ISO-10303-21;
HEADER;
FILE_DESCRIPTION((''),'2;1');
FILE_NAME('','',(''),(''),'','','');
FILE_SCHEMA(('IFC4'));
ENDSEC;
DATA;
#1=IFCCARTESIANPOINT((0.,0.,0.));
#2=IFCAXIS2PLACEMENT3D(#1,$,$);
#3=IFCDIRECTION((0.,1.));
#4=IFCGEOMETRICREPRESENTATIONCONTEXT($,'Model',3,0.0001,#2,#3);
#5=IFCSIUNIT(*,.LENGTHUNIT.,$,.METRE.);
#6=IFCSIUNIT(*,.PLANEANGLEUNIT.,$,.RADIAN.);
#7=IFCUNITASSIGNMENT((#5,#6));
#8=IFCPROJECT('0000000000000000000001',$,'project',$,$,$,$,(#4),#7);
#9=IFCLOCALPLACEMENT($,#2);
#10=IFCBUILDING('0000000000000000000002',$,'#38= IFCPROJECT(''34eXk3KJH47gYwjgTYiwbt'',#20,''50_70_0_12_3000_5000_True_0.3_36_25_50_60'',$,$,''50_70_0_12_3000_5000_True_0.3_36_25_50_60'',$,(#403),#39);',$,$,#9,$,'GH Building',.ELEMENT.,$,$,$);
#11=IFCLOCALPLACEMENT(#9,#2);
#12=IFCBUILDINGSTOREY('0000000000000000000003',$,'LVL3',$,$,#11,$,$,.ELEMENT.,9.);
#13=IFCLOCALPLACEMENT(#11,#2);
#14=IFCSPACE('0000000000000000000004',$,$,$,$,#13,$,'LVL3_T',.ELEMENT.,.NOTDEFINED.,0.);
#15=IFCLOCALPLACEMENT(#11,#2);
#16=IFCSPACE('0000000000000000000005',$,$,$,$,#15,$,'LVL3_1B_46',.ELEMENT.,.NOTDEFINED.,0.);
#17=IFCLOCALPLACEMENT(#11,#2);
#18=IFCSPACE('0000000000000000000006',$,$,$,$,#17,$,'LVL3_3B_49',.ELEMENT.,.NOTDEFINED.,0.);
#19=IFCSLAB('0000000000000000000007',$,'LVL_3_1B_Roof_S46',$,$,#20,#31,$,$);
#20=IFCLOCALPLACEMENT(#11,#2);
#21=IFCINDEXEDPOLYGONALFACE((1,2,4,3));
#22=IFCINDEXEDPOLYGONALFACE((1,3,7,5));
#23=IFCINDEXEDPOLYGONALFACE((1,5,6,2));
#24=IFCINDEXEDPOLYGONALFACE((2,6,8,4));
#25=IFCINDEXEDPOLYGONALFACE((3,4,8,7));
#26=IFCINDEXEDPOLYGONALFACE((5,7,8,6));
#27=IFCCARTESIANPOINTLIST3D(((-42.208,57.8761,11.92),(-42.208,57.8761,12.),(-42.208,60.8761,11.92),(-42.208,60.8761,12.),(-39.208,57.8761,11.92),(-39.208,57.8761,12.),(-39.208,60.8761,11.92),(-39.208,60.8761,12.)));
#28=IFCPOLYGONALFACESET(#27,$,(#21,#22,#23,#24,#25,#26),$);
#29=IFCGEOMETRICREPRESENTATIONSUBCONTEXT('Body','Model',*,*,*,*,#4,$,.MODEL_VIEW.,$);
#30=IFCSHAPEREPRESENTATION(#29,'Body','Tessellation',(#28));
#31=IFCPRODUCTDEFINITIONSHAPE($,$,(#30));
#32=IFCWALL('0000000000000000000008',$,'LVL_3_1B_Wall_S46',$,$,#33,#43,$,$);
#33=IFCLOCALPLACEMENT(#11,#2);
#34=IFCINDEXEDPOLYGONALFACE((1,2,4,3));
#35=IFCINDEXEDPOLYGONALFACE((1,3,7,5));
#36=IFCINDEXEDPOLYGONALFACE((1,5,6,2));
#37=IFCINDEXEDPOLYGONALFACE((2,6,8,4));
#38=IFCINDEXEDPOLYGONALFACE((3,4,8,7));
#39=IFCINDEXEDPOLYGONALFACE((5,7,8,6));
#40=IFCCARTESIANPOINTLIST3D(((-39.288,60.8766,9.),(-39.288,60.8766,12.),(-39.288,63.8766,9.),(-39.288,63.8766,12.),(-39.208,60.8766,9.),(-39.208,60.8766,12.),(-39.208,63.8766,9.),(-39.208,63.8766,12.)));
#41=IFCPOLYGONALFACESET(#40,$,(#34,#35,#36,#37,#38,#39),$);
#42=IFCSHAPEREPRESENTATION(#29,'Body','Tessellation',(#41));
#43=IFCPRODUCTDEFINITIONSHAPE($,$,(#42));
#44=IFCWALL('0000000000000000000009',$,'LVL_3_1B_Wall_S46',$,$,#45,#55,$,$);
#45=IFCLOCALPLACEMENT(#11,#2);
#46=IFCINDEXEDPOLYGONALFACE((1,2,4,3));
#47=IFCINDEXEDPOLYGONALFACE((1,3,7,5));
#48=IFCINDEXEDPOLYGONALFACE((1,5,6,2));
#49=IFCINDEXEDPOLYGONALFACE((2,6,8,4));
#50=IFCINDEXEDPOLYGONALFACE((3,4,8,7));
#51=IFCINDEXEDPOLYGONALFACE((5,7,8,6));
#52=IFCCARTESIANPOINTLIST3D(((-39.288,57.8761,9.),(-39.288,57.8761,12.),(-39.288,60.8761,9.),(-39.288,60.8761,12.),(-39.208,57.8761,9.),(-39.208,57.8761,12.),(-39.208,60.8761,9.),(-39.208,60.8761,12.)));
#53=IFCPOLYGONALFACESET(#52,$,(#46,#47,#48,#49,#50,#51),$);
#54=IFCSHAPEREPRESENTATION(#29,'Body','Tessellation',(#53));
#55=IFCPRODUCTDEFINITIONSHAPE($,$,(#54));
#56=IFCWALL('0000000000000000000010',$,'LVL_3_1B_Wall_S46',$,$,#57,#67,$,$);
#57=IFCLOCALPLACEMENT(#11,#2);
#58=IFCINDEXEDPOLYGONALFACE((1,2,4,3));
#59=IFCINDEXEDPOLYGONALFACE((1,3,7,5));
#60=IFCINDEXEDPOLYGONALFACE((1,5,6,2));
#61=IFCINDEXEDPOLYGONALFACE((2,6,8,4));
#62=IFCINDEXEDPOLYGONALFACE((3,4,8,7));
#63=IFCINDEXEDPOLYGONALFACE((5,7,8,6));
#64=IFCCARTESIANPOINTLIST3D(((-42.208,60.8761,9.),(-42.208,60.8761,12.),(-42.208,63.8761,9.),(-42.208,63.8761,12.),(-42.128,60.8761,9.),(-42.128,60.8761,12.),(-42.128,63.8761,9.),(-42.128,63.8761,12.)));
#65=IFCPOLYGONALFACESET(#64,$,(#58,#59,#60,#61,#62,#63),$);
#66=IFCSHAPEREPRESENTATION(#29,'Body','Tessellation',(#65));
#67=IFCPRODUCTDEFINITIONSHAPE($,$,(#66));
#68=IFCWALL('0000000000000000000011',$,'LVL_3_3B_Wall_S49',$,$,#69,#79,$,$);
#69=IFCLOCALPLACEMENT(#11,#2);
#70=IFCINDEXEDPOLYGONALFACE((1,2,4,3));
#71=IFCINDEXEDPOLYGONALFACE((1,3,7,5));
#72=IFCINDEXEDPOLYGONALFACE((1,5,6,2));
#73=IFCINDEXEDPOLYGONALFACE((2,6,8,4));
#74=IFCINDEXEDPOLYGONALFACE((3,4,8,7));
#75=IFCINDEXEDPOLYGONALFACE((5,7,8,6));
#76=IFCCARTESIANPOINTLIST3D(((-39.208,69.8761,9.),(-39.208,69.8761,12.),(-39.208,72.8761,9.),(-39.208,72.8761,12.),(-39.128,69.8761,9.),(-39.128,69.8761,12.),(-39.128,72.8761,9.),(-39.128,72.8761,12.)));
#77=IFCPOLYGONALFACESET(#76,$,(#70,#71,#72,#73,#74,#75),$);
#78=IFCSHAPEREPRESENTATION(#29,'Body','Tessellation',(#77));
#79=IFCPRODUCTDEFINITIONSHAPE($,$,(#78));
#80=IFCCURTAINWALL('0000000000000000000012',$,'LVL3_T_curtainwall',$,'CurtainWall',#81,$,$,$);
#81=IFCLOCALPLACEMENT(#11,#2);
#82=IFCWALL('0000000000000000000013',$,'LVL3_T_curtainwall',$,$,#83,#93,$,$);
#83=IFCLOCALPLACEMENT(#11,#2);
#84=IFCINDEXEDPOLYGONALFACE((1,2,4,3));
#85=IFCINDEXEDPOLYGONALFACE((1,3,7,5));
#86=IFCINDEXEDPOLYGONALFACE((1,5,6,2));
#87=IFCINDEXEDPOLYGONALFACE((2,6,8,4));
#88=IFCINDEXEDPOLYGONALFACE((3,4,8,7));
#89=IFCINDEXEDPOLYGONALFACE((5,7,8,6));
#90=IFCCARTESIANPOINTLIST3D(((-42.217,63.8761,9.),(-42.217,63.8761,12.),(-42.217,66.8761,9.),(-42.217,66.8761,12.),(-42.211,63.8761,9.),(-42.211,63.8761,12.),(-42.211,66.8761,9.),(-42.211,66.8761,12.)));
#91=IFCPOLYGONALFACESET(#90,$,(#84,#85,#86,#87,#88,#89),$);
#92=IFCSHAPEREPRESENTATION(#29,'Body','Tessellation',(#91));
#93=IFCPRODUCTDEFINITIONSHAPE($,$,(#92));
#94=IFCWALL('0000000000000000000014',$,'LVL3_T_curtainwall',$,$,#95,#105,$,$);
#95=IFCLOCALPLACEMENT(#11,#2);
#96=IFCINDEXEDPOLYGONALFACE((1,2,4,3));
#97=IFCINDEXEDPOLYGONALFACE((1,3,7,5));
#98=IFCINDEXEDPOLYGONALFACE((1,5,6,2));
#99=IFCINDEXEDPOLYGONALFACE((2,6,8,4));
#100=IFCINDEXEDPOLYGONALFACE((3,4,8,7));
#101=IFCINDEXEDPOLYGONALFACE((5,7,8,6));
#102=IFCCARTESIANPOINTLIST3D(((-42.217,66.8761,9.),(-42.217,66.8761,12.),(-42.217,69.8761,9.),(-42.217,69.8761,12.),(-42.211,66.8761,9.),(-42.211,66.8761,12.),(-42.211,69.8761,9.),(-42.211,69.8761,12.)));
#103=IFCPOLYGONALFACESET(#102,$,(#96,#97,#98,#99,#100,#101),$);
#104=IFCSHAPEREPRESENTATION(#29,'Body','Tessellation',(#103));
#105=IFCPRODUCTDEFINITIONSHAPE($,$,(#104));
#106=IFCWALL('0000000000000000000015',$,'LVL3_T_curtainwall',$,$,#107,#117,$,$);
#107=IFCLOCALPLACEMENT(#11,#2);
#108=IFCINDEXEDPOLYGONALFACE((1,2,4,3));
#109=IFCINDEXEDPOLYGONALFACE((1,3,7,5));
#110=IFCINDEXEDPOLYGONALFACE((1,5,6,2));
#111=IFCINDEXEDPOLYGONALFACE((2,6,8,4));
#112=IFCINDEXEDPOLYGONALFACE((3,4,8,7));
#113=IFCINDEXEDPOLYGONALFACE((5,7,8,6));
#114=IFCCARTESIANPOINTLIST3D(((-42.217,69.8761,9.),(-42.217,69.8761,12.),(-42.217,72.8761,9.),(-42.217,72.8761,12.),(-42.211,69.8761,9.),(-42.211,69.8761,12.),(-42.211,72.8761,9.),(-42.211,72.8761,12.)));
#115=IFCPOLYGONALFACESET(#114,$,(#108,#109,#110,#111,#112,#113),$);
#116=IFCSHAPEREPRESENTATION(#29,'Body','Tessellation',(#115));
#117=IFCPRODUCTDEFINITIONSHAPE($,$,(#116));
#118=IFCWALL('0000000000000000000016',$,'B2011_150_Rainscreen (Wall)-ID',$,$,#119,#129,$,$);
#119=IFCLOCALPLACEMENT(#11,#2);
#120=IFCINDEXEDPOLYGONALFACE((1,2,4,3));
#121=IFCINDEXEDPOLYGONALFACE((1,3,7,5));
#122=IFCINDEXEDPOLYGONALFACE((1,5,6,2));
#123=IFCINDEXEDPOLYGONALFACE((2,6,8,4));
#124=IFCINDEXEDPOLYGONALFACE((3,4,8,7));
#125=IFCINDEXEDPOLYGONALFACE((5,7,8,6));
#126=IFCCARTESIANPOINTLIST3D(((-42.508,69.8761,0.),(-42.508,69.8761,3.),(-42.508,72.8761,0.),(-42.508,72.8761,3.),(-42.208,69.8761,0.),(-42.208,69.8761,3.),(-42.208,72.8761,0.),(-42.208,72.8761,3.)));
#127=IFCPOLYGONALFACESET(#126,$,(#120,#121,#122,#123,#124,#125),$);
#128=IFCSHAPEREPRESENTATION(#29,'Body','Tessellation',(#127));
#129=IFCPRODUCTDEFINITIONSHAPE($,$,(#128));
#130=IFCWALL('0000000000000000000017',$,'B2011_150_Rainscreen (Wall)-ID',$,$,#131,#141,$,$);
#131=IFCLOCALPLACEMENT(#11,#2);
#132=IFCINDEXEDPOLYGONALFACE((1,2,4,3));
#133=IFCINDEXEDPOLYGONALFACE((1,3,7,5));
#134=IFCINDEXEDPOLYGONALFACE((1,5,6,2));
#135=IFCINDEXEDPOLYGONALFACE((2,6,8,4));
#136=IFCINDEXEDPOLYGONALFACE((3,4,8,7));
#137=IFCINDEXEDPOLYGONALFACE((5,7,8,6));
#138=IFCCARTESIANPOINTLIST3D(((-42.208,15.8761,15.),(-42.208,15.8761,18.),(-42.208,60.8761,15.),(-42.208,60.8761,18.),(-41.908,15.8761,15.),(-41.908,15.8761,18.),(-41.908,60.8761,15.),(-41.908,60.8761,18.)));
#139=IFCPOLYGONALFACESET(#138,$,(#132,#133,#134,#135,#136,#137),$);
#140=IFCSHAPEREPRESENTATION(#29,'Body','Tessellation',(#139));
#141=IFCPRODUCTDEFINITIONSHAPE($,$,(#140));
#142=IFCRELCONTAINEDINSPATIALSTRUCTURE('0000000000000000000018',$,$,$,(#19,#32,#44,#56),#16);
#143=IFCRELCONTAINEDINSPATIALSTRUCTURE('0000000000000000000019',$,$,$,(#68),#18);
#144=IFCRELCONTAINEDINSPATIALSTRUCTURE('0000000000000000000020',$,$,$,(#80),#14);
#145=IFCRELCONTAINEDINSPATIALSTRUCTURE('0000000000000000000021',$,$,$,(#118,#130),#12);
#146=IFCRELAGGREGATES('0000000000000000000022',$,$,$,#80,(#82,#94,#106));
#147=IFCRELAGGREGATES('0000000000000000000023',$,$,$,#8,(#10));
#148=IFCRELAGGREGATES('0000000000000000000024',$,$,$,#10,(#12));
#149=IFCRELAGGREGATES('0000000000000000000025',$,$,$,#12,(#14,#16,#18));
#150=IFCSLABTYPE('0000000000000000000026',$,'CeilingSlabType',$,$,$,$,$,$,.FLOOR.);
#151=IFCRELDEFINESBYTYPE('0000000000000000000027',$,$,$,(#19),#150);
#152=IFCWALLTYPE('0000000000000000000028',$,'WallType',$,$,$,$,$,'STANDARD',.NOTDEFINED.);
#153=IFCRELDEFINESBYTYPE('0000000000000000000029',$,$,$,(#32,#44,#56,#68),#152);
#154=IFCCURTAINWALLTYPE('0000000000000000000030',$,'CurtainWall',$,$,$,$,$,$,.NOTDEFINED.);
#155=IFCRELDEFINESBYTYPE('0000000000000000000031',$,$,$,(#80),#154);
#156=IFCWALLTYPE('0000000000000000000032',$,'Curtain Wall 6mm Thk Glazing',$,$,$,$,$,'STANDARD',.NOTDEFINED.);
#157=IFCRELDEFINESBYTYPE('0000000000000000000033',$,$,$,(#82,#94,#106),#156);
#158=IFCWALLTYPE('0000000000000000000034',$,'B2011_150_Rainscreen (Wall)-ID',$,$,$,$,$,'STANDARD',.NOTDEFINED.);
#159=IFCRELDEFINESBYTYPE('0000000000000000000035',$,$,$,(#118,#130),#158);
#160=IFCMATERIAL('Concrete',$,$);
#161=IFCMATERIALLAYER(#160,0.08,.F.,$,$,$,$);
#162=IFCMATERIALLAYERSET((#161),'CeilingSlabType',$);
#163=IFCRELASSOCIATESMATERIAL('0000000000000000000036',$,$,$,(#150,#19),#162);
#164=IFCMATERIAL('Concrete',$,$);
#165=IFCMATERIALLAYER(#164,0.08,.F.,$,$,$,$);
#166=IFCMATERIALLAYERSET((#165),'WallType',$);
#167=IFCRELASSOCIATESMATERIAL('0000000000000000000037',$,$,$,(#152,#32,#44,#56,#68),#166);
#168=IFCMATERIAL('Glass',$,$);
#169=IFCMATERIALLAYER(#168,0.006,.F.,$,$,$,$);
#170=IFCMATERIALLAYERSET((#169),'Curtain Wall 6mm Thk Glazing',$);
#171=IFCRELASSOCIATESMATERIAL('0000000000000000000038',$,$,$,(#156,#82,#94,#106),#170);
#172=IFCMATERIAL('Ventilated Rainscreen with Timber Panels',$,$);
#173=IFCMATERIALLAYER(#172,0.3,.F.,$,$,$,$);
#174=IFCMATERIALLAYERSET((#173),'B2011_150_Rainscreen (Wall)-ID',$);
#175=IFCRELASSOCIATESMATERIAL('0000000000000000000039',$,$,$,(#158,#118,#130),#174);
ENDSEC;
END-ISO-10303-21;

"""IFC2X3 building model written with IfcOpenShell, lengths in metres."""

from ifc_helpers import new_model, si_unit, direction, frame, frame_2d, origin, place, context, subcontext, project, spatial, rectangle, extrude, material, layer, layer_set, layer_usage, type_object, element, aggregate, save


model = new_model("IFC2X3")

# Units and contexts
model_context = context("Model", 3, precision=0.0001, world=origin(), true_north=direction((0.0, 1.0)))
body_context = subcontext(model_context, "Body", "Model", "MODEL_VIEW")
ifc_project = project(units=[si_unit("LENGTHUNIT", "METRE"), si_unit("PLANEANGLEUNIT", "RADIAN")], contexts=[model_context])

# Building, storey, space
building_placement = place(None, origin())
building = spatial("IfcBuilding", under=ifc_project, at=building_placement, Name="#38= IFCPROJECT('34eXk3KJH47gYwjgTYiwbt',#20,'50_70_0_12_3000_5000_True_0.3_36_25_50_60',$,$,'50_70_0_12_3000_5000_True_0.3_36_25_50_60',$,(#403),#39);", LongName="GH Building", CompositionType="ELEMENT")
storey_placement = place(building_placement, origin())
storey = spatial("IfcBuildingStorey", under=building, at=storey_placement, Name="LVL3", CompositionType="ELEMENT", Elevation=9.0)
space_1_placement = place(storey_placement, origin())
space_1 = spatial("IfcSpace", under=storey, at=space_1_placement, LongName="LVL3_T", CompositionType="ELEMENT", InteriorOrExteriorSpace="NOTDEFINED", ElevationWithFlooring=0.0)

# Shared definitions
space_2_placement = place(storey_placement, origin())
space_2 = spatial("IfcSpace", under=storey, at=space_2_placement, LongName="LVL3_1B_46", CompositionType="ELEMENT", InteriorOrExteriorSpace="NOTDEFINED", ElevationWithFlooring=0.0)

# Slab
ifc_material_1 = material(Name="Concrete")
ifc_layer_1 = layer(ifc_material_1, 0.08, ventilated=False)
ifc_layer_set_1 = layer_set([ifc_layer_1], Name="CeilingSlabType")
slab_type_1 = type_object("IfcSlabType", Name="CeilingSlabType", PredefinedType="FLOOR", material=ifc_layer_set_1)
ifc_layer_usage_1 = layer_usage(ifc_layer_set_1, "AXIS3", "NEGATIVE", -0.08)
slab_1_placement = place(space_2_placement, frame((-42.208, 60.8761, 11.92), z_axis=(0.0, 0.0, 1.0), x_axis=(0.0, -1.0, 0.0)))
element("IfcSlab", 1, at=slab_1_placement, inside=space_2, type_object=slab_type_1, material=ifc_layer_usage_1, Name="LVL_3_1B_Roof_S46", context=body_context, shape_type="SweptSolid", body=[
    extrude(rectangle(XDim=3.0, YDim=3.0, at=frame_2d((1.5, 1.5))), origin(), (0.0, 0.0, 1.0), 0.08),
])

# Walls
ifc_material_2 = material(Name="Concrete")
ifc_layer_2 = layer(ifc_material_2, 0.08, ventilated=False)
ifc_layer_set_2 = layer_set([ifc_layer_2], Name="WallType")
ifc_layer_usage_2 = layer_usage(ifc_layer_set_2, "AXIS2", "NEGATIVE", 0.0)
wall_type_1 = type_object("IfcWallType", Name="WallType", ElementType="STANDARD", PredefinedType="NOTDEFINED", material=ifc_layer_set_2)
wall_1_placement = place(space_2_placement, frame((-39.208, 63.8766, 9.0), z_axis=(0.0, 0.0, 1.0), x_axis=(0.0, -1.0, 0.0)))
element("IfcWall", 2, at=wall_1_placement, inside=space_2, type_object=wall_type_1, material=ifc_layer_usage_2, Name="LVL_3_1B_Wall_S46", context=body_context, shape_type="SweptSolid", body=[
    extrude(rectangle(XDim=3.0, YDim=0.08, at=frame_2d((1.5, -0.04))), origin(), (0.0, 0.0, 1.0), 3.0),
])
ifc_layer_usage_3 = layer_usage(ifc_layer_set_2, "AXIS2", "NEGATIVE", 0.0)
wall_2_placement = place(space_2_placement, frame((-39.208, 60.8761, 9.0), z_axis=(0.0, 0.0, 1.0), x_axis=(0.0, -1.0, 0.0)))
element("IfcWall", 3, at=wall_2_placement, inside=space_2, type_object=wall_type_1, material=ifc_layer_usage_3, Name="LVL_3_1B_Wall_S46", context=body_context, shape_type="SweptSolid", body=[
    extrude(rectangle(XDim=3.0, YDim=0.08, at=frame_2d((1.5, -0.04))), origin(), (0.0, 0.0, 1.0), 3.0),
])
ifc_layer_usage_4 = layer_usage(ifc_layer_set_2, "AXIS2", "NEGATIVE", 0.0)
wall_3_placement = place(space_2_placement, frame((-42.208, 60.8761, 9.0), z_axis=(0.0, 0.0, 1.0), x_axis=(0.0, 1.0, 0.0)))
element("IfcWall", 4, at=wall_3_placement, inside=space_2, type_object=wall_type_1, material=ifc_layer_usage_4, Name="LVL_3_1B_Wall_S46", context=body_context, shape_type="SweptSolid", body=[
    extrude(rectangle(XDim=3.0, YDim=0.08, at=frame_2d((1.5, -0.04))), origin(), (0.0, 0.0, 1.0), 3.0),
])

# Shared definitions
space_3_placement = place(storey_placement, origin())
space_3 = spatial("IfcSpace", under=storey, at=space_3_placement, LongName="LVL3_3B_49", CompositionType="ELEMENT", InteriorOrExteriorSpace="NOTDEFINED", ElevationWithFlooring=0.0)

# Wall
ifc_layer_usage_5 = layer_usage(ifc_layer_set_2, "AXIS2", "NEGATIVE", 0.0)
wall_4_placement = place(space_3_placement, frame((-39.208, 69.8761, 9.0), z_axis=(0.0, 0.0, 1.0), x_axis=(0.0, 1.0, 0.0)))
element("IfcWall", 5, at=wall_4_placement, inside=space_3, type_object=wall_type_1, material=ifc_layer_usage_5, Name="LVL_3_3B_Wall_S49", context=body_context, shape_type="SweptSolid", body=[
    extrude(rectangle(XDim=3.0, YDim=0.08, at=frame_2d((1.5, -0.04))), origin(), (0.0, 0.0, 1.0), 3.0),
])

# Curtain wall, walls
curtain_wall_type = type_object("IfcCurtainWallType", Name="CurtainWall", PredefinedType="NOTDEFINED")
curtain_wall_placement = place(None, origin())
curtain_wall = element("IfcCurtainWall", 6, at=curtain_wall_placement, inside=space_1, type_object=curtain_wall_type, Name="LVL3_T_curtainwall", ObjectType="CurtainWall")
ifc_material_3 = material(Name="Glass")
ifc_layer_3 = layer(ifc_material_3, 0.006, ventilated=False)
ifc_layer_set_3 = layer_set([ifc_layer_3], Name="Curtain Wall 6mm Thk Glazing")
ifc_layer_usage_6 = layer_usage(ifc_layer_set_3, "AXIS2", "NEGATIVE", -0.003)
wall_type_2 = type_object("IfcWallType", Name="Curtain Wall 6mm Thk Glazing", ElementType="STANDARD", PredefinedType="NOTDEFINED", material=ifc_layer_set_3)
wall_5_placement = place(curtain_wall_placement, frame((-42.208, 66.8761, 9.0), z_axis=(0.0, 0.0, 1.0), x_axis=(0.0, -1.0, 0.0)))
wall_5 = element("IfcWall", 7, at=wall_5_placement, type_object=wall_type_2, material=ifc_layer_usage_6, Name="LVL3_T_curtainwall", context=body_context, shape_type="SweptSolid", body=[
    extrude(rectangle(XDim=3.0, YDim=0.006, at=frame_2d((1.5, -0.006))), origin(), (0.0, 0.0, 1.0), 3.0),
])
ifc_layer_usage_7 = layer_usage(ifc_layer_set_3, "AXIS2", "NEGATIVE", -0.003)
wall_6_placement = place(curtain_wall_placement, frame((-42.208, 69.8761, 9.0), z_axis=(0.0, 0.0, 1.0), x_axis=(0.0, -1.0, 0.0)))
wall_6 = element("IfcWall", 8, at=wall_6_placement, type_object=wall_type_2, material=ifc_layer_usage_7, Name="LVL3_T_curtainwall", context=body_context, shape_type="SweptSolid", body=[
    extrude(rectangle(XDim=3.0, YDim=0.006, at=frame_2d((1.5, -0.006))), origin(), (0.0, 0.0, 1.0), 3.0),
])
ifc_layer_usage_8 = layer_usage(ifc_layer_set_3, "AXIS2", "NEGATIVE", -0.003)
wall_7_placement = place(curtain_wall_placement, frame((-42.208, 72.8761, 9.0), z_axis=(0.0, 0.0, 1.0), x_axis=(0.0, -1.0, 0.0)))
wall_7 = element("IfcWall", 9, at=wall_7_placement, type_object=wall_type_2, material=ifc_layer_usage_8, Name="LVL3_T_curtainwall", context=body_context, shape_type="SweptSolid", body=[
    extrude(rectangle(XDim=3.0, YDim=0.006, at=frame_2d((1.5, -0.006))), origin(), (0.0, 0.0, 1.0), 3.0),
])
aggregate(curtain_wall, [wall_5, wall_6, wall_7])

# Walls
ifc_material_4 = material(Name="Ventilated Rainscreen with Timber Panels")
ifc_layer_4 = layer(ifc_material_4, 0.3, ventilated=False)
ifc_layer_set_4 = layer_set([ifc_layer_4], Name="B2011_150_Rainscreen (Wall)-ID")
ifc_layer_usage_9 = layer_usage(ifc_layer_set_4, "AXIS2", "POSITIVE", 0.0)
wall_type_3 = type_object("IfcWallType", Name="B2011_150_Rainscreen (Wall)-ID", ElementType="STANDARD", PredefinedType="NOTDEFINED", material=ifc_layer_set_4)
wall_8_placement = place(storey_placement, frame((-42.208, 69.8761, 0.0), z_axis=(0.0, 0.0, 1.0), x_axis=(0.0, 1.0, 0.0)))
element("IfcWall", 10, at=wall_8_placement, inside=storey, type_object=wall_type_3, material=ifc_layer_usage_9, Name="B2011_150_Rainscreen (Wall)-ID", context=body_context, shape_type="SweptSolid", body=[
    extrude(rectangle(XDim=3.0, YDim=0.3, at=frame_2d((1.5, 0.15))), origin(), (0.0, 0.0, 1.0), 3.0),
])
ifc_layer_usage_10 = layer_usage(ifc_layer_set_4, "AXIS2", "POSITIVE", 0.0)
wall_9_placement = place(storey_placement, frame((-42.208, 60.8761, 15.0), z_axis=(0.0, 0.0, 1.0), x_axis=(0.0, -1.0, 0.0)))
element("IfcWall", 11, at=wall_9_placement, inside=storey, type_object=wall_type_3, material=ifc_layer_usage_10, Name="B2011_150_Rainscreen (Wall)-ID", context=body_context, shape_type="SweptSolid", body=[
    extrude(rectangle(XDim=45.0, YDim=0.3, at=frame_2d((22.5, 0.15))), origin(), (0.0, 0.0, 1.0), 3.0),
])

save(model, "model.ifc")
